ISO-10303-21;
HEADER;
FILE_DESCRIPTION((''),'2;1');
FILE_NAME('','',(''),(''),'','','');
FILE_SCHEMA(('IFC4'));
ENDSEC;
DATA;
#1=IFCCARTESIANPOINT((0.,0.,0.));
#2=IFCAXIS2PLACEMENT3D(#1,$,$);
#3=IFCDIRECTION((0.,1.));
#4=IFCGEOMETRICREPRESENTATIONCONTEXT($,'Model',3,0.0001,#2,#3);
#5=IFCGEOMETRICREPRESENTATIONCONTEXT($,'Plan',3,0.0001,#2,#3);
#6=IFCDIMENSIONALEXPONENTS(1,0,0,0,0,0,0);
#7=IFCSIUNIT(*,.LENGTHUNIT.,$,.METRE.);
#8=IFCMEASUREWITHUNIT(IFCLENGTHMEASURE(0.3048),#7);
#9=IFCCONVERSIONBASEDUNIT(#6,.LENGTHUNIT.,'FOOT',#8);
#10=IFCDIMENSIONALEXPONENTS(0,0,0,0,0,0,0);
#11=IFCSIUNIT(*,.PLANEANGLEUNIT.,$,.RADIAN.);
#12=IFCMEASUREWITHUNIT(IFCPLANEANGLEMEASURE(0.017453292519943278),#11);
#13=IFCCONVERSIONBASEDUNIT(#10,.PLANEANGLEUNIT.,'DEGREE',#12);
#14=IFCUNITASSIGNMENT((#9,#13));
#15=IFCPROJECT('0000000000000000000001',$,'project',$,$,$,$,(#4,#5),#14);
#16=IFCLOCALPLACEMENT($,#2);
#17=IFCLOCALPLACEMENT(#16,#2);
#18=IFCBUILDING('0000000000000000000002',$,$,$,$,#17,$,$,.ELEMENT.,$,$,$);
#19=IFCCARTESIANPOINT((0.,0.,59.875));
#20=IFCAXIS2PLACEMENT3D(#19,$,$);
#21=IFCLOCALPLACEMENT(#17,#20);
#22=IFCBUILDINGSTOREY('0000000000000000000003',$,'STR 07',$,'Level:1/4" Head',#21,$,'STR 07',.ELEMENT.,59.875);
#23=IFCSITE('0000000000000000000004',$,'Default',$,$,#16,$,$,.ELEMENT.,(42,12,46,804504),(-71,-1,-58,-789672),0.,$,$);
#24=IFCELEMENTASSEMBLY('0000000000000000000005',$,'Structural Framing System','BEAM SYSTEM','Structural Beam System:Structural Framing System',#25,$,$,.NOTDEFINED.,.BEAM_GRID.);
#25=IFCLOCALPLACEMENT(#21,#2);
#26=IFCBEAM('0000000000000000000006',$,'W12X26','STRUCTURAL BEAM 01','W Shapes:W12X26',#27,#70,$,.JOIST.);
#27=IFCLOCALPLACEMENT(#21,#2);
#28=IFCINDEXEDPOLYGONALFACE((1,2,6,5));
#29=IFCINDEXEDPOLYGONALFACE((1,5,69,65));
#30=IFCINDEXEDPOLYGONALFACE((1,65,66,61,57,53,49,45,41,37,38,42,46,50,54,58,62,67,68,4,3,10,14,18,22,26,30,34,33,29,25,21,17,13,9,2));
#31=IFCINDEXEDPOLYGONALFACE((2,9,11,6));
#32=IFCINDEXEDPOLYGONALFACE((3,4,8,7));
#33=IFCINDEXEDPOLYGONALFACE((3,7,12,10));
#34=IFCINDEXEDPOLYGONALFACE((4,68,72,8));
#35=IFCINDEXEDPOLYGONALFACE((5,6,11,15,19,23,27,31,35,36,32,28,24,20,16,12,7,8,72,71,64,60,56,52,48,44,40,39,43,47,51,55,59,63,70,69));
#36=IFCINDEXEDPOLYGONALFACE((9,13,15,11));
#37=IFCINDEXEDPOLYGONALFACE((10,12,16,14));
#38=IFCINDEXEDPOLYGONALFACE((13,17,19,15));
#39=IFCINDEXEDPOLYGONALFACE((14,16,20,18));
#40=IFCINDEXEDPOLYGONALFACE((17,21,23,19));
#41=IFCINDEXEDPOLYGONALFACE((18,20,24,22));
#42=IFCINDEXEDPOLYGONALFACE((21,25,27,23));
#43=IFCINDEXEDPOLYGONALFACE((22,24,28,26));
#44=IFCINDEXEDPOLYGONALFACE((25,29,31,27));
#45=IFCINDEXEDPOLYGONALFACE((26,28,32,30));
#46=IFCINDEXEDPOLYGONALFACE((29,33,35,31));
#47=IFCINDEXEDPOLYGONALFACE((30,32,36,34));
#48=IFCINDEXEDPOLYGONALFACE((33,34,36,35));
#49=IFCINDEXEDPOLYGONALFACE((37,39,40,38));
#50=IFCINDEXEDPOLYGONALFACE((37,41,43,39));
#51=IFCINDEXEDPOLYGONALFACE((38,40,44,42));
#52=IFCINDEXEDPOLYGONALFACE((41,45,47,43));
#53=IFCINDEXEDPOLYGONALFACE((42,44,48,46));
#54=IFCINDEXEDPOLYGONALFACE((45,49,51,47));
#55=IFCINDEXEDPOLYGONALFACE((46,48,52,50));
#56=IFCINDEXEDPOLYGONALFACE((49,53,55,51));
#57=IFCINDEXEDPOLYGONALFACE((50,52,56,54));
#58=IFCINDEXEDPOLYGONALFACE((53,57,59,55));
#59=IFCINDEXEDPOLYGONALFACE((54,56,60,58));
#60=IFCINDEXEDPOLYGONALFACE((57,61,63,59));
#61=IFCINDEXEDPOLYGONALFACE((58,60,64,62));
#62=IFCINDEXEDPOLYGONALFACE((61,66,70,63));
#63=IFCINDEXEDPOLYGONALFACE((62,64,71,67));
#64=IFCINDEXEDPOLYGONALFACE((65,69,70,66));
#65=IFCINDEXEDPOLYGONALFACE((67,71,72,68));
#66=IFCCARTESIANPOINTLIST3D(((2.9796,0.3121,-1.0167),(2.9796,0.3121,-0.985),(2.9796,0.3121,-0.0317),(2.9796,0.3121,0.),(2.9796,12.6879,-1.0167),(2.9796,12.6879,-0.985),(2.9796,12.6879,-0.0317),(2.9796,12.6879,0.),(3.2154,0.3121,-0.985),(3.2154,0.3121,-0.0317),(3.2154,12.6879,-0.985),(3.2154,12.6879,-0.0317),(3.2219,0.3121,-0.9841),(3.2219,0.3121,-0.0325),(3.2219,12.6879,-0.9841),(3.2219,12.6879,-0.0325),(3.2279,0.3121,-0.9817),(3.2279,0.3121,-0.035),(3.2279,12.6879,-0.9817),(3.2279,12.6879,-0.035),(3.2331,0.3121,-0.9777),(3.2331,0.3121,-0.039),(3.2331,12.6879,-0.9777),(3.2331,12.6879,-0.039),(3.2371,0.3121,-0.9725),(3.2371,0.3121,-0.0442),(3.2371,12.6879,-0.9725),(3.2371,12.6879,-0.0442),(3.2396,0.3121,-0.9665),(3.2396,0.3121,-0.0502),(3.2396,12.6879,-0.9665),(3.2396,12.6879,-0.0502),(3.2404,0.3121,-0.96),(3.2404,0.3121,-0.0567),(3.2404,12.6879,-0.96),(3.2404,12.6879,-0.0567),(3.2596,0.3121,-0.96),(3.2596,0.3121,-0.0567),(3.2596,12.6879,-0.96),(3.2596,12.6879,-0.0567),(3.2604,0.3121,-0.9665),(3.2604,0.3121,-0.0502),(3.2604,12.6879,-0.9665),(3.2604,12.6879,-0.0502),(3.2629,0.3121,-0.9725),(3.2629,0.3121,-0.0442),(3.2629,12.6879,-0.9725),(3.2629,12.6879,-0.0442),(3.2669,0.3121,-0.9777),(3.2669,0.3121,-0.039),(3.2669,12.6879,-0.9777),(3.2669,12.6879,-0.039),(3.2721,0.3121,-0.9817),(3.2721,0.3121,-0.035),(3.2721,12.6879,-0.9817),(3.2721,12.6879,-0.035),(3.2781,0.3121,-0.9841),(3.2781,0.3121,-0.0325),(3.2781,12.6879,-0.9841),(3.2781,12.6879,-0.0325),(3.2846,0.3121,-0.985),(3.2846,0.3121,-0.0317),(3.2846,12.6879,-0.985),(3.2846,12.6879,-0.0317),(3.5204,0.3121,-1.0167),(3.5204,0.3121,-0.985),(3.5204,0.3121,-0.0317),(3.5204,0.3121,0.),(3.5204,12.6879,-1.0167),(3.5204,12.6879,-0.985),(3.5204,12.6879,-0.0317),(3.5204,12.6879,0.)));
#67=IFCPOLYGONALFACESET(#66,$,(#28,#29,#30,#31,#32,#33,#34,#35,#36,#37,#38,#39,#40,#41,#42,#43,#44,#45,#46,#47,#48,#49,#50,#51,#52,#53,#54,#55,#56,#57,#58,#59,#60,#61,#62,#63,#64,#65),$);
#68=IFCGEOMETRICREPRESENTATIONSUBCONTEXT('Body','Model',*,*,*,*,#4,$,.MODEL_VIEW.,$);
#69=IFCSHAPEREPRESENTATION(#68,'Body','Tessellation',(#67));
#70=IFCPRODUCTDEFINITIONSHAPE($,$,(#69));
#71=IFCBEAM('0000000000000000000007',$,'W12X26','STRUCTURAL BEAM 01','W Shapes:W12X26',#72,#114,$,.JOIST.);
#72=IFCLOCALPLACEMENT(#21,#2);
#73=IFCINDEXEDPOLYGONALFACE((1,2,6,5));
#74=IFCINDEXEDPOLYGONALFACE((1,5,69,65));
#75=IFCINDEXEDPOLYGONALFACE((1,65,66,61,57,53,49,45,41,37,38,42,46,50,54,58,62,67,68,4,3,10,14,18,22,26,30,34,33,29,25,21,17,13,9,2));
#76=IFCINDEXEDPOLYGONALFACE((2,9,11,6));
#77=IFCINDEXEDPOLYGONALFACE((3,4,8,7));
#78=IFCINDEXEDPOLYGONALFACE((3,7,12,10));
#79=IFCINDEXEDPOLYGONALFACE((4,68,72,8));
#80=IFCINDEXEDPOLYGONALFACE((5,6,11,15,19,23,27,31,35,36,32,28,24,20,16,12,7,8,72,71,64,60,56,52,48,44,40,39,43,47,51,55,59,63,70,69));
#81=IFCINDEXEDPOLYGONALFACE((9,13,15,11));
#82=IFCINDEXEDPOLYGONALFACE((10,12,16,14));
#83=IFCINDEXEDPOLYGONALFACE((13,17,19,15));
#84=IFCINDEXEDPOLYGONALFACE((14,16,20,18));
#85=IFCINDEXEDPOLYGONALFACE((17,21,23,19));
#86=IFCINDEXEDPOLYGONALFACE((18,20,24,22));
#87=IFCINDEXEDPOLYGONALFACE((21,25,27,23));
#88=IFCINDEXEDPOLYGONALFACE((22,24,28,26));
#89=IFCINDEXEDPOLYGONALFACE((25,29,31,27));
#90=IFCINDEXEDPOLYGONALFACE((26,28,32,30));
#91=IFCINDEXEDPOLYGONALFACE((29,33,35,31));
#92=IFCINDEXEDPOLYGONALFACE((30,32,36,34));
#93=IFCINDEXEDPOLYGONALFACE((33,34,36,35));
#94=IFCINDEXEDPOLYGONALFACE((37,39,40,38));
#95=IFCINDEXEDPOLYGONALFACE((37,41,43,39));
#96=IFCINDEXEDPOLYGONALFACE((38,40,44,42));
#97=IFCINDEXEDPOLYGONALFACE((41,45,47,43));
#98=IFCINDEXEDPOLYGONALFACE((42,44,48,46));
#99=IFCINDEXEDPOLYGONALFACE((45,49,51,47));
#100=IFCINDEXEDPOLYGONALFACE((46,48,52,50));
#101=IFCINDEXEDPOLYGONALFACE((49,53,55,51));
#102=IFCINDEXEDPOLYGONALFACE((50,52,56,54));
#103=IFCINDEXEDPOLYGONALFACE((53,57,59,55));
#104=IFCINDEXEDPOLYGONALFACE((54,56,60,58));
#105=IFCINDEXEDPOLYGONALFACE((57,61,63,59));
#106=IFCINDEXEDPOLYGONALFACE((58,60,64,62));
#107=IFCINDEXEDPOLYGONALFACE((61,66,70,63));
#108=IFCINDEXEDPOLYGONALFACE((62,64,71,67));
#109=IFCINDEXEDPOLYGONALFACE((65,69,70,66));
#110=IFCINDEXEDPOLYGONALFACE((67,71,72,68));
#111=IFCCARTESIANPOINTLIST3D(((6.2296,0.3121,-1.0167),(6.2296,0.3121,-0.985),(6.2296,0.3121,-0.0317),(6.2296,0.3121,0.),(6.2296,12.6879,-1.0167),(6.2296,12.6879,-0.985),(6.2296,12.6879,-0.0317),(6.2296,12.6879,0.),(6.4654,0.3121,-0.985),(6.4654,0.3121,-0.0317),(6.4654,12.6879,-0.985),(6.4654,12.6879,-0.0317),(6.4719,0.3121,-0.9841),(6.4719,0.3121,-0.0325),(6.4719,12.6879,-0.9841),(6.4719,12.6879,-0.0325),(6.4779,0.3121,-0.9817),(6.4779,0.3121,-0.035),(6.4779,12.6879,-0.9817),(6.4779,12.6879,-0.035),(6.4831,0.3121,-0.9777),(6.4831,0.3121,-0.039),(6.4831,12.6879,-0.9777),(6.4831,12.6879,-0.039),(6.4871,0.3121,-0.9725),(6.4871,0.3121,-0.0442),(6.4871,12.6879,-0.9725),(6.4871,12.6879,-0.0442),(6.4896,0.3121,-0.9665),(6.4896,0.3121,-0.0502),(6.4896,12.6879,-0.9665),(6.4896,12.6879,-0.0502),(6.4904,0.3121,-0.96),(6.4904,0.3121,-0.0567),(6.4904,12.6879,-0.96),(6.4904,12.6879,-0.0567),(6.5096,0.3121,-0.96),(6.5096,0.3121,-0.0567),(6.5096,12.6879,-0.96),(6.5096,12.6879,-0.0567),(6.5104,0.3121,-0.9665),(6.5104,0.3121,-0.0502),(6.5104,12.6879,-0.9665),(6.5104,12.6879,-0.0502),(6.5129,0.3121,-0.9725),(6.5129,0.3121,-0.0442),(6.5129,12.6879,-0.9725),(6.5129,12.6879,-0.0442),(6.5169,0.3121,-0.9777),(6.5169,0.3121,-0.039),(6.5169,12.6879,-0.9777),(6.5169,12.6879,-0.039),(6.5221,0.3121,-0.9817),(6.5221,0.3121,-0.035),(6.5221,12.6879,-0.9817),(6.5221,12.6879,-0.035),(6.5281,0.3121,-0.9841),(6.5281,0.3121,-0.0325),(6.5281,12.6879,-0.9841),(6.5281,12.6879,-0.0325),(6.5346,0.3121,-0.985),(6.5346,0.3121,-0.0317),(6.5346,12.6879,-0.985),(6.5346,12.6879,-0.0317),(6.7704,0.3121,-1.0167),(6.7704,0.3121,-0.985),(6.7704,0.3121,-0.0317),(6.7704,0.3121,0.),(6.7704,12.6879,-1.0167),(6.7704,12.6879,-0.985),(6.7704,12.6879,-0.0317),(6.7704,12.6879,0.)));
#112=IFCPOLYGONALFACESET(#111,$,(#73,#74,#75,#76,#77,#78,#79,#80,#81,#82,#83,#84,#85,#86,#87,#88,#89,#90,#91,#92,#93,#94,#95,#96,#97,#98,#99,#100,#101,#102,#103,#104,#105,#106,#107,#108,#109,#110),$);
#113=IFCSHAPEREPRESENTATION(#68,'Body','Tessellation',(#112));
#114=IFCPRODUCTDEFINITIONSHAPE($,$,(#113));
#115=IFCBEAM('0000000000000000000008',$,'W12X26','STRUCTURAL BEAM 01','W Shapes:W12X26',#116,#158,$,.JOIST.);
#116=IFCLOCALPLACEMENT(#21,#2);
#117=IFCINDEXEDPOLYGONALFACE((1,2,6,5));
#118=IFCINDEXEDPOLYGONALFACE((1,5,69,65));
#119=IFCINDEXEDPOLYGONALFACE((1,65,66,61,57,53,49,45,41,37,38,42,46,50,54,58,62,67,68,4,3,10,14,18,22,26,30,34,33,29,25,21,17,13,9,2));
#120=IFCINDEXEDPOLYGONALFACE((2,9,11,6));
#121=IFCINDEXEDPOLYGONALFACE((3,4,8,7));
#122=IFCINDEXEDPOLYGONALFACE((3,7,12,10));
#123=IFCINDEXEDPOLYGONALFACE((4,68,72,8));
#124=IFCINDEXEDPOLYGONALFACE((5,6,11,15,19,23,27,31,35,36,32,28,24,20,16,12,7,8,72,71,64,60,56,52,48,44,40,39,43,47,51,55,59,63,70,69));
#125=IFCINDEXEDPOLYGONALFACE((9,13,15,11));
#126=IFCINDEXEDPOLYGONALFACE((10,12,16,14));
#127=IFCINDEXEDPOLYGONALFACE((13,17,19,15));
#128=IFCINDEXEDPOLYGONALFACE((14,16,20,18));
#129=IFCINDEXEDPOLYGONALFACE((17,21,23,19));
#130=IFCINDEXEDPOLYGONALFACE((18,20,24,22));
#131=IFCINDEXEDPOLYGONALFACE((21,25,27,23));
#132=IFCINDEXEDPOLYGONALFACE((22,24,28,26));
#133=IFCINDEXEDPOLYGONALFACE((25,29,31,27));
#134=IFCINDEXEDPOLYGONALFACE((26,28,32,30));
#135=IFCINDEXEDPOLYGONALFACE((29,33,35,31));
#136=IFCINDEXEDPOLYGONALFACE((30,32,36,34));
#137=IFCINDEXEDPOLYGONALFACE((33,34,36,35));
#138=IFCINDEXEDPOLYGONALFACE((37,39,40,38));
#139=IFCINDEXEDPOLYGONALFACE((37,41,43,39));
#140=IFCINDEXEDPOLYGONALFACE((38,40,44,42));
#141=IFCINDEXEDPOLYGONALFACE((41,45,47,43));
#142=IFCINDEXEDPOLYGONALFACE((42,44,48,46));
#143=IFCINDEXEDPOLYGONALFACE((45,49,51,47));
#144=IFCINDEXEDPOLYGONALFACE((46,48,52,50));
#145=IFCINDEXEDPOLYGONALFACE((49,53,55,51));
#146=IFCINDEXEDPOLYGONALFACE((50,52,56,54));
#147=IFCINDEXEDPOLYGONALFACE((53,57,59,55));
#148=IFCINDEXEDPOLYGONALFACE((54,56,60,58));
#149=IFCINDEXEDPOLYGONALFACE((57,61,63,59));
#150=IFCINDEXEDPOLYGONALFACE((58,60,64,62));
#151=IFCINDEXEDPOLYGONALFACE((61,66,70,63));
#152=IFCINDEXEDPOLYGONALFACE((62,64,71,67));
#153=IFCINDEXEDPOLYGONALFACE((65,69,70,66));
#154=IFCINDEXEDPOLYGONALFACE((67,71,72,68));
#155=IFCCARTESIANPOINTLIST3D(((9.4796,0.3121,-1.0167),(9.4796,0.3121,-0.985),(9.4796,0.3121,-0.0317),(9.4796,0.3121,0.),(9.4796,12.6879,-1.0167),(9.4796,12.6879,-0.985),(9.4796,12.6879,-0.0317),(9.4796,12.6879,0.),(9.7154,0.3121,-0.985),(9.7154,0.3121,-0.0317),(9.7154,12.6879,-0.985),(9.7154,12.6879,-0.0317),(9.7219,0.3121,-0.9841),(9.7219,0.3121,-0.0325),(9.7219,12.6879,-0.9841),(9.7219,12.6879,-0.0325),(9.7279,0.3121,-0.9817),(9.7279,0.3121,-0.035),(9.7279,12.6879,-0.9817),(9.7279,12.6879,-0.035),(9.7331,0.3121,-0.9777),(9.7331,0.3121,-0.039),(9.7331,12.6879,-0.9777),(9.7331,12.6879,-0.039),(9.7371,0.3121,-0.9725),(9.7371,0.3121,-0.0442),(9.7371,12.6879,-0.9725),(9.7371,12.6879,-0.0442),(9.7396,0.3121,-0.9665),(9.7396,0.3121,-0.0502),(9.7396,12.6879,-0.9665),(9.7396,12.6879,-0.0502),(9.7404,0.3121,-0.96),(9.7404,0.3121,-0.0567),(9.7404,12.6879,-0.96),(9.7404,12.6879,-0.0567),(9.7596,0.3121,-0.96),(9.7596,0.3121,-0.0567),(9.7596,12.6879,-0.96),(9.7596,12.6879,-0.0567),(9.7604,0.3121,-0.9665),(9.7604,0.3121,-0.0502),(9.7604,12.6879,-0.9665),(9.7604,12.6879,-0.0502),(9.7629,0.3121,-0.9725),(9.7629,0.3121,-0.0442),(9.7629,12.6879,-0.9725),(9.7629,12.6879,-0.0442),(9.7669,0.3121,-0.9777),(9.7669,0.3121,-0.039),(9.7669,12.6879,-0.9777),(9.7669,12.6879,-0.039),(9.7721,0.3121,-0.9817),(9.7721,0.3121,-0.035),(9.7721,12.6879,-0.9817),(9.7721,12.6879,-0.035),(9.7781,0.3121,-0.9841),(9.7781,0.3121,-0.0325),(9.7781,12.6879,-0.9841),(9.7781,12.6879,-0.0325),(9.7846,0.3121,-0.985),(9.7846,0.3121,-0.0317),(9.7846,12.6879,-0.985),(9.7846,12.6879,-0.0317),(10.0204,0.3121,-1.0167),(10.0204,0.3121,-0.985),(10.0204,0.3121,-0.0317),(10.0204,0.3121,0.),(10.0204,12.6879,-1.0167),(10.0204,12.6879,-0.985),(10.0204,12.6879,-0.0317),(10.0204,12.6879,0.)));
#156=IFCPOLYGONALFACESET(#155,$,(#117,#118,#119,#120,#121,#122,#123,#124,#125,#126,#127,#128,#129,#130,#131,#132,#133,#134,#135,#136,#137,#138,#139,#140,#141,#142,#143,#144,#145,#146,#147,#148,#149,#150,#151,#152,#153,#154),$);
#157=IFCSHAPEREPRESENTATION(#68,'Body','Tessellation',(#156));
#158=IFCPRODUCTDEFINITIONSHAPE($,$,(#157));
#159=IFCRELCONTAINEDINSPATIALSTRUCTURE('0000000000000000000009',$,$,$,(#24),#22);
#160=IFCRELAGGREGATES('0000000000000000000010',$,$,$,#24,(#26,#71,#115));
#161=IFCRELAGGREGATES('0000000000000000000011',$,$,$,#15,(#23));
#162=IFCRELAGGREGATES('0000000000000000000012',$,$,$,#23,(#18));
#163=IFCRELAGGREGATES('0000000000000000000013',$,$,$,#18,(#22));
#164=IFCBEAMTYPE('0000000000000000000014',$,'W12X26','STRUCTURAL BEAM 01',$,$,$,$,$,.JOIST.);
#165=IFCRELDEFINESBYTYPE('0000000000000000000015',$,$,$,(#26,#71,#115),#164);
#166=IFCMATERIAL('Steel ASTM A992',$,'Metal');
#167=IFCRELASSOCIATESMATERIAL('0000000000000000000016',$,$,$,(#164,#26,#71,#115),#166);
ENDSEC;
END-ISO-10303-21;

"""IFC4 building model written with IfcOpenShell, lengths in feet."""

from ifc_helpers import new_model, entity, si_unit, converted_unit, direction, frame, origin, place, context, subcontext, project, spatial, line, arc, indexed_curve, outline, extrude, source, transform, mapped, material, type_object, type_shapes, element, aggregate, save


model = new_model("IFC4")

# Units and contexts
model_context = context("Model", 3, precision=0.0001, world=origin(), true_north=direction((0.0, 1.0)))
plan_context = context("Plan", 3, precision=0.0001, world=origin(), true_north=direction((0.0, 1.0)))
body_context = subcontext(model_context, "Body", "Model", "MODEL_VIEW")
ifc_project = project(units=[converted_unit("LENGTHUNIT", "FOOT", entity("IfcLengthMeasure", 0.3048), si_unit("LENGTHUNIT", "METRE"), dimensions=[1, 0, 0, 0, 0, 0, 0]), converted_unit("PLANEANGLEUNIT", "DEGREE", entity("IfcPlaneAngleMeasure", 0.017453292519943278), si_unit("PLANEANGLEUNIT", "RADIAN"), dimensions=[0, 0, 0, 0, 0, 0, 0])], contexts=[model_context, plan_context])

# Site, building, storey
site_placement = place(None, origin())
site = spatial("IfcSite", under=ifc_project, at=site_placement, Name="Default", CompositionType="ELEMENT", RefLatitude=(42, 12, 46, 804504), RefLongitude=(-71, -1, -58, -789672), RefElevation=0.0)
building_placement = place(site_placement, origin())
building = spatial("IfcBuilding", under=site, at=building_placement, CompositionType="ELEMENT")
storey_placement = place(building_placement, frame((0.0, 0.0, 59.875)))
storey = spatial("IfcBuildingStorey", under=building, at=storey_placement, Name="STR 07", ObjectType="Level:1/4\" Head", LongName="STR 07", CompositionType="ELEMENT", Elevation=59.875)

# Element assembly, beams
assembly_1_placement = place(storey_placement, origin())
assembly_1 = element("IfcElementAssembly", 1, at=assembly_1_placement, inside=storey, Name="Structural Framing System", Description="BEAM SYSTEM", ObjectType="Structural Beam System:Structural Framing System", AssemblyPlace="NOTDEFINED", PredefinedType="BEAM_GRID")
ifc_material = material(Name="Steel ASTM A992", Category="Metal")
beam_type_1 = type_object("IfcBeamType", Name="W12X26", Description="STRUCTURAL BEAM 01", PredefinedType="JOIST", material=ifc_material)
shared_shape = source(origin(), body_context, "Body", "SweptSolid", [
    extrude(outline(indexed_curve([(-0.2704, -0.4767), (-0.2704, -0.5083), (0.2704, -0.5083), (0.2704, -0.4767), (0.0346, -0.4767), (0.0169, -0.4693), (0.0096, -0.4517), (0.0096, 0.4517), (0.0169, 0.4693), (0.0346, 0.4767), (0.2704, 0.4767), (0.2704, 0.5083), (-0.2704, 0.5083), (-0.2704, 0.4767), (-0.0346, 0.4767), (-0.0169, 0.4693), (-0.0096, 0.4517), (-0.0096, -0.4517), (-0.0169, -0.4693), (-0.0346, -0.4767)], segments=[line(1, 2, 3, 4, 5), arc(5, 6, 7), line(7, 8), arc(8, 9, 10), line(10, 11, 12, 13, 14, 15), arc(15, 16, 17), line(17, 18), arc(18, 19, 20), line(20, 1)], self_intersect=False)), frame((-6.1879, 0.0, 0.0), z_axis=(-1.0, 0.0, 0.0), x_axis=(0.0, -1.0, 0.0)), (0.0, 0.0, -1.0), 12.3758),
])
type_shapes(beam_type_1, [shared_shape])
beam_1_placement = place(assembly_1_placement, frame((3.25, 6.5, -0.5083), z_axis=(0.0, 0.0, 1.0), x_axis=(0.0, 1.0, 0.0)))
beam_1 = element("IfcBeam", 2, at=beam_1_placement, type_object=beam_type_1, material=ifc_material, Name="W12X26", Description="STRUCTURAL BEAM 01", ObjectType="W Shapes:W12X26", PredefinedType="JOIST", context=body_context, shape_type="MappedRepresentation", body=[
    mapped(shared_shape, transform((0.0, 0.0, 0.0), scale=1.0)),
])
beam_2_placement = place(assembly_1_placement, frame((6.5, 6.5, -0.5083), z_axis=(0.0, 0.0, 1.0), x_axis=(0.0, 1.0, 0.0)))
beam_2 = element("IfcBeam", 3, at=beam_2_placement, type_object=beam_type_1, material=ifc_material, Name="W12X26", Description="STRUCTURAL BEAM 01", ObjectType="W Shapes:W12X26", PredefinedType="JOIST", context=body_context, shape_type="MappedRepresentation", body=[
    mapped(shared_shape, transform((0.0, 0.0, 0.0), scale=1.0)),
])
beam_3_placement = place(assembly_1_placement, frame((9.75, 6.5, -0.5083), z_axis=(0.0, 0.0, 1.0), x_axis=(0.0, 1.0, 0.0)))
beam_3 = element("IfcBeam", 4, at=beam_3_placement, type_object=beam_type_1, material=ifc_material, Name="W12X26", Description="STRUCTURAL BEAM 01", ObjectType="W Shapes:W12X26", PredefinedType="JOIST", context=body_context, shape_type="MappedRepresentation", body=[
    mapped(shared_shape, transform((0.0, 0.0, 0.0), scale=1.0)),
])
aggregate(assembly_1, [beam_1, beam_2, beam_3])

save(model, "model.ifc")
